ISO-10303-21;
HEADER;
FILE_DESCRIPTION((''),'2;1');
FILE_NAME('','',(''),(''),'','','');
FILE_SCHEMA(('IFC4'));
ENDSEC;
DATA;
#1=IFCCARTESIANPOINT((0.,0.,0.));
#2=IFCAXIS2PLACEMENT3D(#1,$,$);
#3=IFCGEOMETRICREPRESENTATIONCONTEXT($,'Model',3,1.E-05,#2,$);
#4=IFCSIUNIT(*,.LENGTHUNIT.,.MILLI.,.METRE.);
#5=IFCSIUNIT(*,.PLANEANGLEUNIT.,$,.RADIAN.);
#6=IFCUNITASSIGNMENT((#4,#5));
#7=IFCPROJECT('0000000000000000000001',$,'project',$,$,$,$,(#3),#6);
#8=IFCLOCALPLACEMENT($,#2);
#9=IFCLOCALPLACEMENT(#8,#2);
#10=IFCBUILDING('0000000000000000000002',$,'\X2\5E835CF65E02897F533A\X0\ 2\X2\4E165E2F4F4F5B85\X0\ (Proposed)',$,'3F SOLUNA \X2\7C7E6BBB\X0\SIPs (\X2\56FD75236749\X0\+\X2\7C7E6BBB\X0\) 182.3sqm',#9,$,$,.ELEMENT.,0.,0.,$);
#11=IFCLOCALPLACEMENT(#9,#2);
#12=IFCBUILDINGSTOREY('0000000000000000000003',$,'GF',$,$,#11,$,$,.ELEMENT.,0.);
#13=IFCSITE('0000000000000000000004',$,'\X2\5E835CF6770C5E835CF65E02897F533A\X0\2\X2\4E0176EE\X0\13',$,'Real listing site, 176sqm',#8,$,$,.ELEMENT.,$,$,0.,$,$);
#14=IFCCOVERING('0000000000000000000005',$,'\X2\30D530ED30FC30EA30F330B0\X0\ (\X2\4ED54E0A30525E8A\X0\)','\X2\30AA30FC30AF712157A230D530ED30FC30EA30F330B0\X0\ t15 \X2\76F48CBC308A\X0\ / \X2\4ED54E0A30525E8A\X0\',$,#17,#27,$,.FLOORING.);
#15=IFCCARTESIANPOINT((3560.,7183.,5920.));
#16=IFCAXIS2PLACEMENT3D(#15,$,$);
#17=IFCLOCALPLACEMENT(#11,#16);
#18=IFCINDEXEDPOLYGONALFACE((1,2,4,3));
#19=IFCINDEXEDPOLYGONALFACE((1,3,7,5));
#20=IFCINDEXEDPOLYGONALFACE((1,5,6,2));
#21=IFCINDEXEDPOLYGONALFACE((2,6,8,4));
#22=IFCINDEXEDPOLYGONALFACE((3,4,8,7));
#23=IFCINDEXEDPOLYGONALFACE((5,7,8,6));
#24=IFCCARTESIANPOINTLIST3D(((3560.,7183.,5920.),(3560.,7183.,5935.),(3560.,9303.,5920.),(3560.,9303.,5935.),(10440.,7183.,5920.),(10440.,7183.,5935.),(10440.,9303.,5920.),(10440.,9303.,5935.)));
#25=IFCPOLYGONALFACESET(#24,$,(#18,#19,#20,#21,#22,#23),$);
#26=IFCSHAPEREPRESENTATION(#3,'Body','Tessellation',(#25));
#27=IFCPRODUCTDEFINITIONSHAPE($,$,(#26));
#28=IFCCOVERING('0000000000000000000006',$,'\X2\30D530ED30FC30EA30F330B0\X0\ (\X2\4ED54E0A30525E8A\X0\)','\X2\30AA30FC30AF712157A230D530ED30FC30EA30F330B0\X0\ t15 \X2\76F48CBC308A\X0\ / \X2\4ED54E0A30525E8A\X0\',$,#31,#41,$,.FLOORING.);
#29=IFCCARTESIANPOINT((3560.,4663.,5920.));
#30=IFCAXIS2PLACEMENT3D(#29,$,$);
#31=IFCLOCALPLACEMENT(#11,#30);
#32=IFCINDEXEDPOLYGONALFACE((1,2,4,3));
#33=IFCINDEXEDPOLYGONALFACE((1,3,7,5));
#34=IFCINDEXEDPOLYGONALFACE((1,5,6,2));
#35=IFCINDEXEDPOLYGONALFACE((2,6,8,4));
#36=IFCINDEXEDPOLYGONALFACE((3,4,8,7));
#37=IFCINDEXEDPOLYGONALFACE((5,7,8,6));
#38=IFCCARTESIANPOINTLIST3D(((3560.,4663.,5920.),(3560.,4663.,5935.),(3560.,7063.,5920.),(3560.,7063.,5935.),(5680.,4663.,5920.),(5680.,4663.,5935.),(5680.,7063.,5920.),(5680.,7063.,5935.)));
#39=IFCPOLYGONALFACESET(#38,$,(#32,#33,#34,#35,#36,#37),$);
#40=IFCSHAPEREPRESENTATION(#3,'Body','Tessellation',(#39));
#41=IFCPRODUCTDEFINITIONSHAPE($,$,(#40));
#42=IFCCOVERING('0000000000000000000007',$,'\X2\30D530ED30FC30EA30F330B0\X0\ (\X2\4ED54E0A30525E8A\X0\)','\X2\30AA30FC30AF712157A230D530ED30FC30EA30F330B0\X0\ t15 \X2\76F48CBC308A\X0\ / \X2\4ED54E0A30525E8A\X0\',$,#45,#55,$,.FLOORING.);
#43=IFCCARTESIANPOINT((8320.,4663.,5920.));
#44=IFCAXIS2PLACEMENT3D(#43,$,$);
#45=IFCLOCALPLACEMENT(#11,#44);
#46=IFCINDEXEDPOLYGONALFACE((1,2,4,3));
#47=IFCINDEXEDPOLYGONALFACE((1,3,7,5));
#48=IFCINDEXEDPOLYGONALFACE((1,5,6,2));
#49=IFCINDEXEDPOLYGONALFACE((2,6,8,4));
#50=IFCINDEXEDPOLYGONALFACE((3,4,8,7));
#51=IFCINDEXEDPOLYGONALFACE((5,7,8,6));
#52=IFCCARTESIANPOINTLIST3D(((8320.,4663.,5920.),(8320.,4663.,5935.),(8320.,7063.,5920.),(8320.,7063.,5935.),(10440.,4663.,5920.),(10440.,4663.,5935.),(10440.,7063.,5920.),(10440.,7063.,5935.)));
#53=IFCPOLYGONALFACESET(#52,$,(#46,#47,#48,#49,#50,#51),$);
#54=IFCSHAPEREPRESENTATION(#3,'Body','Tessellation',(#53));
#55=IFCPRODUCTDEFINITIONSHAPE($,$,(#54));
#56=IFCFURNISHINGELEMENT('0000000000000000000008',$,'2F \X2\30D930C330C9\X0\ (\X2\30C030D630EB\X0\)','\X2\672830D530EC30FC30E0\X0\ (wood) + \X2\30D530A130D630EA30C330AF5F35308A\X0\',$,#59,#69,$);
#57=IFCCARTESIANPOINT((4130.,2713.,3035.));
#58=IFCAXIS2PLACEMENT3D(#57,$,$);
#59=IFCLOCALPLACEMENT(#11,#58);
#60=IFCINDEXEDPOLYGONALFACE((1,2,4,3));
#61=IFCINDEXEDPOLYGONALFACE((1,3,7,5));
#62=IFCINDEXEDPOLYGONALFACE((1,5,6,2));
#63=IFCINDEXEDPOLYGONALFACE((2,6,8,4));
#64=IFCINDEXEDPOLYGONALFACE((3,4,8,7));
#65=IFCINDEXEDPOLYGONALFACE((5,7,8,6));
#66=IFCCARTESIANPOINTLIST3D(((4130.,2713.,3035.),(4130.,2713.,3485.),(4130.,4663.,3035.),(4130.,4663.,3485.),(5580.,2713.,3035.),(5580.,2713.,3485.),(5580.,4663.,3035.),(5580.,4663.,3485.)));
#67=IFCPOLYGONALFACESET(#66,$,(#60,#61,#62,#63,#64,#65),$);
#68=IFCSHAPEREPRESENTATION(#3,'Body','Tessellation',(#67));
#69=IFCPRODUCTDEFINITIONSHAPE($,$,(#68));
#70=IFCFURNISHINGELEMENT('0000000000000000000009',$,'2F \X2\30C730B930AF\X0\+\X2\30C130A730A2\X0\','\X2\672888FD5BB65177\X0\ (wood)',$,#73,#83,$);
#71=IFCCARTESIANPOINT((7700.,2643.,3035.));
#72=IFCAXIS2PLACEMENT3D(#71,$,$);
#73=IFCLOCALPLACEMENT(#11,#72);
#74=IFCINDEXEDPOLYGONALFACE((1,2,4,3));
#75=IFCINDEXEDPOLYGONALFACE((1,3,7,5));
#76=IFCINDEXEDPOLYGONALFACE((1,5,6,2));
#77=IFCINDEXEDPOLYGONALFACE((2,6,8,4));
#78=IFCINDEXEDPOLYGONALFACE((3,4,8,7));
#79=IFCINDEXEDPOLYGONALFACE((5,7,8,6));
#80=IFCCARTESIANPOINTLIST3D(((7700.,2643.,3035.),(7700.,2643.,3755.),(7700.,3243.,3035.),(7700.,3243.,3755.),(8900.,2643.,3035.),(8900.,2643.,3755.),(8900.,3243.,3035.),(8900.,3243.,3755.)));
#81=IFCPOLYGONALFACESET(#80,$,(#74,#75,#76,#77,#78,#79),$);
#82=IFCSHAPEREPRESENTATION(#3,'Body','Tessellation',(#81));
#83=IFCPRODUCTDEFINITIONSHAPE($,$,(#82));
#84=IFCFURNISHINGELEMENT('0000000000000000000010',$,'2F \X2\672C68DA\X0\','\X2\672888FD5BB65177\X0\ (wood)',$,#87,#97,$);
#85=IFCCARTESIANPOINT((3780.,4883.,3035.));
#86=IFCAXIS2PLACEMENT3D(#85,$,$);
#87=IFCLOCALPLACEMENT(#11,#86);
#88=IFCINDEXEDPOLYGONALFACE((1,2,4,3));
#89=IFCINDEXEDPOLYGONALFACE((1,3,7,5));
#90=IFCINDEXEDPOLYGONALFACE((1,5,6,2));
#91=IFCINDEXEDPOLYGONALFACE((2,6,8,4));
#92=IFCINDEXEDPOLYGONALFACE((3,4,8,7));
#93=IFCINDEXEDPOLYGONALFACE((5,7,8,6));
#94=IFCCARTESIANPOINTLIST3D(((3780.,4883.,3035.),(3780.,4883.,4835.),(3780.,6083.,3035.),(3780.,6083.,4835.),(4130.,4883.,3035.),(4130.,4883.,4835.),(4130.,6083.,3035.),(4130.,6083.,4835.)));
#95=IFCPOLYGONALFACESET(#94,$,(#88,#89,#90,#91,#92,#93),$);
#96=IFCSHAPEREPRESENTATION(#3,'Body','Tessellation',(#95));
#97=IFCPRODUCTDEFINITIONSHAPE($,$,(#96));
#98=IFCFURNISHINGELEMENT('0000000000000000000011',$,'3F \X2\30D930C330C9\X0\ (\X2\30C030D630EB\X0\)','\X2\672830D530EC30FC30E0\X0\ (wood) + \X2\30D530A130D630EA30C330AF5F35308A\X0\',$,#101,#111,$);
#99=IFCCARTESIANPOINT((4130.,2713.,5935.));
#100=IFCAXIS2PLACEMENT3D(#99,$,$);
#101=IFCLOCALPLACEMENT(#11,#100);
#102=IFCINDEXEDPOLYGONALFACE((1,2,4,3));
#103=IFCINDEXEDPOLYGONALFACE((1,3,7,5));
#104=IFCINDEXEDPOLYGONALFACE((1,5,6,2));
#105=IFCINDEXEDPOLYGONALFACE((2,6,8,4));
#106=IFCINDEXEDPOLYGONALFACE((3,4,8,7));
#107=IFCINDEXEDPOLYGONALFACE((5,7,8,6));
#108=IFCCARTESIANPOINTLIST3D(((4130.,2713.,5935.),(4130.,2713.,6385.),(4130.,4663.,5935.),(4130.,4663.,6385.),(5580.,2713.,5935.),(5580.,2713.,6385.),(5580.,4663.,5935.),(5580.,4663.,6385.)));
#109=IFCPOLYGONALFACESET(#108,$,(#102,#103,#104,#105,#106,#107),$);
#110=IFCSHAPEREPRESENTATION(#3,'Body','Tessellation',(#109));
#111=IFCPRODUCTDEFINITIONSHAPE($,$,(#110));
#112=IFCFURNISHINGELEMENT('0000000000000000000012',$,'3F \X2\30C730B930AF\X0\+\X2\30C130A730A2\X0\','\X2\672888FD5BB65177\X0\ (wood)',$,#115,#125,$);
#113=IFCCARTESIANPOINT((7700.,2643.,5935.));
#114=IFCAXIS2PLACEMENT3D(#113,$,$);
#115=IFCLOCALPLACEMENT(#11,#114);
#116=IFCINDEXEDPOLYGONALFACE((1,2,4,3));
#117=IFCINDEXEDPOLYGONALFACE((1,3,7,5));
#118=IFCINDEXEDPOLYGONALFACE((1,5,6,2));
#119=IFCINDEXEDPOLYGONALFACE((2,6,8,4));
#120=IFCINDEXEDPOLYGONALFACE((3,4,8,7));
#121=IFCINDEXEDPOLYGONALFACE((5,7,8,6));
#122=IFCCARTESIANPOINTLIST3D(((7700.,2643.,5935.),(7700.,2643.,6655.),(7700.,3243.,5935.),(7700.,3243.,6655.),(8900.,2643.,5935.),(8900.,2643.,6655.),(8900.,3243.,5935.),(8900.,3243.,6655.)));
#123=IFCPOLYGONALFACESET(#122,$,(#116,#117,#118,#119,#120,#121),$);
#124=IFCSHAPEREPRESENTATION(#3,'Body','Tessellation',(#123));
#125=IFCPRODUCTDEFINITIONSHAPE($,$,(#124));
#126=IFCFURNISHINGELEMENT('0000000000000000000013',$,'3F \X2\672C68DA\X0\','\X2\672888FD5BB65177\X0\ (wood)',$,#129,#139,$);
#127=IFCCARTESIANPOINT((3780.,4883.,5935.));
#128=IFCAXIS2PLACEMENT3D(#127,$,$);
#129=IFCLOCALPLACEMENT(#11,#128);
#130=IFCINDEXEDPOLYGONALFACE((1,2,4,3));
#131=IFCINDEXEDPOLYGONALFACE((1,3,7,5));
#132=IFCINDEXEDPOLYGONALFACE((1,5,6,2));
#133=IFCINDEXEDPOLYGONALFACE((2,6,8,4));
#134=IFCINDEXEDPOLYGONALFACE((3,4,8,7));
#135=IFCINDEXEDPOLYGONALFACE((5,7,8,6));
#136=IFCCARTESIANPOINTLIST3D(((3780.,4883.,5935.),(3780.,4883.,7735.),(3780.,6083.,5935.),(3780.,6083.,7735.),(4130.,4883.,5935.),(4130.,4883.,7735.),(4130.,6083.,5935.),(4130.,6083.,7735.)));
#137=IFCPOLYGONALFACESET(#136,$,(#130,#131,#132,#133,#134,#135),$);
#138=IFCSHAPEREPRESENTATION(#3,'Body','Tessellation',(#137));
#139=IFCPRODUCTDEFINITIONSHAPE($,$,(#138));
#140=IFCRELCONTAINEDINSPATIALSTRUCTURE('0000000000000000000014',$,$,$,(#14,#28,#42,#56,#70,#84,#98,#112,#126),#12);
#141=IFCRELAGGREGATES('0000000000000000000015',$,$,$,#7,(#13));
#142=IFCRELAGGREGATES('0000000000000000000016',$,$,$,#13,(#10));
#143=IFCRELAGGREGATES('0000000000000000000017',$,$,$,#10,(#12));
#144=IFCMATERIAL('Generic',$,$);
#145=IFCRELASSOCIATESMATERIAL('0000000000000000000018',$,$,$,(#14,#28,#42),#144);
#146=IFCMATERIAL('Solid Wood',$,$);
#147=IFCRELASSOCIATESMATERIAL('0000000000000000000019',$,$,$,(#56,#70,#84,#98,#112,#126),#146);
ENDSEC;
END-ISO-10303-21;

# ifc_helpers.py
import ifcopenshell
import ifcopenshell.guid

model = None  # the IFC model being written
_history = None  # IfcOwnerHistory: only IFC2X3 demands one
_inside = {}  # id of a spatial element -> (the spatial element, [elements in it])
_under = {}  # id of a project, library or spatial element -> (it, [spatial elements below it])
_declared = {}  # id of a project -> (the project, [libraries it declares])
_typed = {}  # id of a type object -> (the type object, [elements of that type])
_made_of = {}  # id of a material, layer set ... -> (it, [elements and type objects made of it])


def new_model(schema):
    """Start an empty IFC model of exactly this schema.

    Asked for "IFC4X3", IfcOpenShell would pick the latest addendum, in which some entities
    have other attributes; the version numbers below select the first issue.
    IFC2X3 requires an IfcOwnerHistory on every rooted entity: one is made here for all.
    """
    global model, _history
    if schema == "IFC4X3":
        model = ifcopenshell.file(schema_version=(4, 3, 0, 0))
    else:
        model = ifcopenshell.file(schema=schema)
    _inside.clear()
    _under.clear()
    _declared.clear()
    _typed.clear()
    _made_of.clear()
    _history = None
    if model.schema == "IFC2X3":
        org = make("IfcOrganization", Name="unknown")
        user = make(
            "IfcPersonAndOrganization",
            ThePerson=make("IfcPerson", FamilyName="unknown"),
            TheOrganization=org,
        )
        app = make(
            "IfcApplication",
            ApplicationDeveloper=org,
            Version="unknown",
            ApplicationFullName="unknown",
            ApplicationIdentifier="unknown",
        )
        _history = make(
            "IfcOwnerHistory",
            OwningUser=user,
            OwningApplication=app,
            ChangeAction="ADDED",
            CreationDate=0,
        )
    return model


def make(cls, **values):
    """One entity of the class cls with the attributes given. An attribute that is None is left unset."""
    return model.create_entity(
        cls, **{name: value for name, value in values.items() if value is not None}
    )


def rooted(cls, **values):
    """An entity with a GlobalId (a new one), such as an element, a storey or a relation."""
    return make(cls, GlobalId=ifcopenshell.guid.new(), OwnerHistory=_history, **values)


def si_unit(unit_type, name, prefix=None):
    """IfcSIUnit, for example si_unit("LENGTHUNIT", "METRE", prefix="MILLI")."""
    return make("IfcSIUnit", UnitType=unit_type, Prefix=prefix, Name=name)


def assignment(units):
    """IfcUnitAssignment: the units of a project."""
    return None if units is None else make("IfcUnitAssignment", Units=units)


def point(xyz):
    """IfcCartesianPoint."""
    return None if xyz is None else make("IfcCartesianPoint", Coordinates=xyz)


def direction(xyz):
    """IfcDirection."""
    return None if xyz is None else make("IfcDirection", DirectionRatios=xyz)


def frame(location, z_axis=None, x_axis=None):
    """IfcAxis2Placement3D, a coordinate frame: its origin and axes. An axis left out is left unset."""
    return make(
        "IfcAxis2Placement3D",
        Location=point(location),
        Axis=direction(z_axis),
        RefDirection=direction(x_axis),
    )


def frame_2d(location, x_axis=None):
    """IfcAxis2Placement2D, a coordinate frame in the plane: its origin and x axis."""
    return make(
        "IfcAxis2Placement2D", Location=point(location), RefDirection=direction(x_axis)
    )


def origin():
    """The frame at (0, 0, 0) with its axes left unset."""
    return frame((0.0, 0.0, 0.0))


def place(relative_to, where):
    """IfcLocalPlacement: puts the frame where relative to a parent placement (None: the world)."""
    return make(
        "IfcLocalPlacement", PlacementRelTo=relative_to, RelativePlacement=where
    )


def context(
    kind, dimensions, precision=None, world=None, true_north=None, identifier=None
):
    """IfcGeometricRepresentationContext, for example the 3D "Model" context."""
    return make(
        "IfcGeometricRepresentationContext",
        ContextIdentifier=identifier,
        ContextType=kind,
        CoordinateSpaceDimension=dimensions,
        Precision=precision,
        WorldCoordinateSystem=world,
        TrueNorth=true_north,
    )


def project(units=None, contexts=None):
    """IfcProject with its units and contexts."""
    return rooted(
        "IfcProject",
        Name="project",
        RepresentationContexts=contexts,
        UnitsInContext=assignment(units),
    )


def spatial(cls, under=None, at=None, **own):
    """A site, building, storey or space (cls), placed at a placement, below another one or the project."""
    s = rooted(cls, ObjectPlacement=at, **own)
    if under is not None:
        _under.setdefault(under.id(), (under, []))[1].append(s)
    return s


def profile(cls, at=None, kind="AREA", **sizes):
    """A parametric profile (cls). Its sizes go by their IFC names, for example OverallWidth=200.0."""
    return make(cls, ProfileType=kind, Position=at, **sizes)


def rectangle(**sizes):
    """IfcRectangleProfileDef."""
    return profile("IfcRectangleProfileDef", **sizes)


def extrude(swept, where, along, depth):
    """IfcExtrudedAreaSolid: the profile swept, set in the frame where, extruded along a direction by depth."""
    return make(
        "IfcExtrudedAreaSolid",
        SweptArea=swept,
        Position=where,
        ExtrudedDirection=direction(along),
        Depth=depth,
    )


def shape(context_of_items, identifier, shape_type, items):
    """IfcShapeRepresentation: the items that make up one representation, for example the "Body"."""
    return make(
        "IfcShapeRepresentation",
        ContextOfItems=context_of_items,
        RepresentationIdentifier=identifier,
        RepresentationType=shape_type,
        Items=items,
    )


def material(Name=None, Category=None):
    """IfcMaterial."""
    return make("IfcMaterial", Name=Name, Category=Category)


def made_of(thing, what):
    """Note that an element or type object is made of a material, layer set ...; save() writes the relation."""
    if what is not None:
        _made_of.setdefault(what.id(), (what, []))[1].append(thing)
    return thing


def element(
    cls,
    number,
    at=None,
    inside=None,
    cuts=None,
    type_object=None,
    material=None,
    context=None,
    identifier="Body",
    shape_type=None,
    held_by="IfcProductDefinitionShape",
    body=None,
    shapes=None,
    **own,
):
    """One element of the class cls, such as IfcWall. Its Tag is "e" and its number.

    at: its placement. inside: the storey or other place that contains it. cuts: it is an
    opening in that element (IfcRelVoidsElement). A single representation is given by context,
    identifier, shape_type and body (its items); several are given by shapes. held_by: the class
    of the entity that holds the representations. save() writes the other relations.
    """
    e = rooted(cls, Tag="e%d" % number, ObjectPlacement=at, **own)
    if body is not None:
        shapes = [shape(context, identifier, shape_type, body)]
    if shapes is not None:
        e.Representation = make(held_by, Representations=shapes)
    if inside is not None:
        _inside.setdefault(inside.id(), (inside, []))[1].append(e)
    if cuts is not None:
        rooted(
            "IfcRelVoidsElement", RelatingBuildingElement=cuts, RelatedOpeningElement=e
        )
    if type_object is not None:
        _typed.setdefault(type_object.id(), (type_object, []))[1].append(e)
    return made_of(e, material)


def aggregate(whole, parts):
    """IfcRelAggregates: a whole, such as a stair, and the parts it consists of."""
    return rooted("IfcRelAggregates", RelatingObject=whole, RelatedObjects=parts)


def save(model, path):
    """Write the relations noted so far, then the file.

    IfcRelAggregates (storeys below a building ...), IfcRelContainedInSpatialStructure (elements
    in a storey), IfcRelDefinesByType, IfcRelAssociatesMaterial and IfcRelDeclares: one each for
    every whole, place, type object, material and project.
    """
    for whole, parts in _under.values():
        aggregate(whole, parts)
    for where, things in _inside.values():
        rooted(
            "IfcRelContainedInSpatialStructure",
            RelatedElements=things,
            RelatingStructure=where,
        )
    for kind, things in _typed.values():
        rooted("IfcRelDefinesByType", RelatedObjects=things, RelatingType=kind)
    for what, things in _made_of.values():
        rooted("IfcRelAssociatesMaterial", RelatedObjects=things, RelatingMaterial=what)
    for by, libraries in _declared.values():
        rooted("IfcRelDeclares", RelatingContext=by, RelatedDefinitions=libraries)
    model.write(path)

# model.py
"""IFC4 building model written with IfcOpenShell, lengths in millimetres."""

from ifc_helpers import new_model, si_unit, frame, frame_2d, origin, place, context, project, spatial, rectangle, extrude, material, element, save


model = new_model("IFC4")

# Units and contexts
model_context = context("Model", 3, precision=1e-05, world=origin())
ifc_project = project(units=[si_unit("LENGTHUNIT", "METRE", prefix="MILLI"), si_unit("PLANEANGLEUNIT", "RADIAN")], contexts=[model_context])

# Site, building, storey
site_placement = place(None, origin())
site = spatial("IfcSite", under=ifc_project, at=site_placement, Name="広島県広島市西区2丁目13", ObjectType="Real listing site, 176sqm", CompositionType="ELEMENT", RefElevation=0.0)
building_placement = place(site_placement, origin())
building = spatial("IfcBuilding", under=site, at=building_placement, Name="広島市西区 2世帯住宅 (Proposed)", ObjectType="3F SOLUNA 籾殻SIPs (国産杉+籾殻) 182.3sqm", CompositionType="ELEMENT", ElevationOfRefHeight=0.0, ElevationOfTerrain=0.0)
storey_placement = place(building_placement, origin())
storey = spatial("IfcBuildingStorey", under=building, at=storey_placement, Name="GF", CompositionType="ELEMENT", Elevation=0.0)

# Shared definitions
ifc_material_1 = material(Name="Solid Wood")

# Shared definitions
ifc_material_2 = material(Name="Generic")

# Coverings
covering_1_placement = place(storey_placement, frame((3560.0, 7183.0, 5920.0)))
element("IfcCovering", 1, at=covering_1_placement, inside=storey, material=ifc_material_2, Name="フローリング (仕上げ床)", Description="オーク無垢フローリング t15 直貼り / 仕上げ床", PredefinedType="FLOORING", context=model_context, shape_type="SweptSolid", body=[
    extrude(rectangle(XDim=6880.0, YDim=2120.0, at=frame_2d((3440.0, 1060.0))), frame((3560.0, 7183.0, 5920.0)), (0.0, 0.0, 1.0), 15.0),
])
covering_2_placement = place(storey_placement, frame((3560.0, 4663.0, 5920.0)))
element("IfcCovering", 2, at=covering_2_placement, inside=storey, material=ifc_material_2, Name="フローリング (仕上げ床)", Description="オーク無垢フローリング t15 直貼り / 仕上げ床", PredefinedType="FLOORING", context=model_context, shape_type="SweptSolid", body=[
    extrude(rectangle(XDim=2120.0, YDim=2400.0, at=frame_2d((1060.0, 1200.0))), frame((3560.0, 4663.0, 5920.0)), (0.0, 0.0, 1.0), 15.0),
])
covering_3_placement = place(storey_placement, frame((8320.0, 4663.0, 5920.0)))
element("IfcCovering", 3, at=covering_3_placement, inside=storey, material=ifc_material_2, Name="フローリング (仕上げ床)", Description="オーク無垢フローリング t15 直貼り / 仕上げ床", PredefinedType="FLOORING", context=model_context, shape_type="SweptSolid", body=[
    extrude(rectangle(XDim=2120.0, YDim=2400.0, at=frame_2d((1060.0, 1200.0))), frame((8320.0, 4663.0, 5920.0)), (0.0, 0.0, 1.0), 15.0),
])

# Furnishing elements
furnishing_1_placement = place(storey_placement, frame((4130.0, 2713.0, 3035.0)))
element("IfcFurnishingElement", 4, at=furnishing_1_placement, inside=storey, material=ifc_material_1, Name="2F ベッド (ダブル)", Description="木フレーム (wood) + ファブリック張り", context=model_context, shape_type="SweptSolid", body=[
    extrude(rectangle(XDim=1450.0, YDim=1950.0, at=frame_2d((725.0, 975.0))), frame((4130.0, 2713.0, 3035.0)), (0.0, 0.0, 1.0), 450.0),
])
furnishing_2_placement = place(storey_placement, frame((7700.0, 2643.0, 3035.0)))
element("IfcFurnishingElement", 5, at=furnishing_2_placement, inside=storey, material=ifc_material_1, Name="2F デスク+チェア", Description="木製家具 (wood)", context=model_context, shape_type="SweptSolid", body=[
    extrude(rectangle(XDim=1200.0, YDim=600.0, at=frame_2d((600.0, 300.0))), frame((7700.0, 2643.0, 3035.0)), (0.0, 0.0, 1.0), 720.0),
])
furnishing_3_placement = place(storey_placement, frame((3780.0, 4883.0, 3035.0)))
element("IfcFurnishingElement", 6, at=furnishing_3_placement, inside=storey, material=ifc_material_1, Name="2F 本棚", Description="木製家具 (wood)", context=model_context, shape_type="SweptSolid", body=[
    extrude(rectangle(XDim=350.0, YDim=1200.0, at=frame_2d((175.0, 600.0))), frame((3780.0, 4883.0, 3035.0)), (0.0, 0.0, 1.0), 1800.0),
])
furnishing_4_placement = place(storey_placement, frame((4130.0, 2713.0, 5935.0)))
element("IfcFurnishingElement", 7, at=furnishing_4_placement, inside=storey, material=ifc_material_1, Name="3F ベッド (ダブル)", Description="木フレーム (wood) + ファブリック張り", context=model_context, shape_type="SweptSolid", body=[
    extrude(rectangle(XDim=1450.0, YDim=1950.0, at=frame_2d((725.0, 975.0))), frame((4130.0, 2713.0, 5935.0)), (0.0, 0.0, 1.0), 450.0),
])
furnishing_5_placement = place(storey_placement, frame((7700.0, 2643.0, 5935.0)))
element("IfcFurnishingElement", 8, at=furnishing_5_placement, inside=storey, material=ifc_material_1, Name="3F デスク+チェア", Description="木製家具 (wood)", context=model_context, shape_type="SweptSolid", body=[
    extrude(rectangle(XDim=1200.0, YDim=600.0, at=frame_2d((600.0, 300.0))), frame((7700.0, 2643.0, 5935.0)), (0.0, 0.0, 1.0), 720.0),
])
furnishing_6_placement = place(storey_placement, frame((3780.0, 4883.0, 5935.0)))
element("IfcFurnishingElement", 9, at=furnishing_6_placement, inside=storey, material=ifc_material_1, Name="3F 本棚", Description="木製家具 (wood)", context=model_context, shape_type="SweptSolid", body=[
    extrude(rectangle(XDim=350.0, YDim=1200.0, at=frame_2d((175.0, 600.0))), frame((3780.0, 4883.0, 5935.0)), (0.0, 0.0, 1.0), 1800.0),
])

save(model, "model.ifc")
